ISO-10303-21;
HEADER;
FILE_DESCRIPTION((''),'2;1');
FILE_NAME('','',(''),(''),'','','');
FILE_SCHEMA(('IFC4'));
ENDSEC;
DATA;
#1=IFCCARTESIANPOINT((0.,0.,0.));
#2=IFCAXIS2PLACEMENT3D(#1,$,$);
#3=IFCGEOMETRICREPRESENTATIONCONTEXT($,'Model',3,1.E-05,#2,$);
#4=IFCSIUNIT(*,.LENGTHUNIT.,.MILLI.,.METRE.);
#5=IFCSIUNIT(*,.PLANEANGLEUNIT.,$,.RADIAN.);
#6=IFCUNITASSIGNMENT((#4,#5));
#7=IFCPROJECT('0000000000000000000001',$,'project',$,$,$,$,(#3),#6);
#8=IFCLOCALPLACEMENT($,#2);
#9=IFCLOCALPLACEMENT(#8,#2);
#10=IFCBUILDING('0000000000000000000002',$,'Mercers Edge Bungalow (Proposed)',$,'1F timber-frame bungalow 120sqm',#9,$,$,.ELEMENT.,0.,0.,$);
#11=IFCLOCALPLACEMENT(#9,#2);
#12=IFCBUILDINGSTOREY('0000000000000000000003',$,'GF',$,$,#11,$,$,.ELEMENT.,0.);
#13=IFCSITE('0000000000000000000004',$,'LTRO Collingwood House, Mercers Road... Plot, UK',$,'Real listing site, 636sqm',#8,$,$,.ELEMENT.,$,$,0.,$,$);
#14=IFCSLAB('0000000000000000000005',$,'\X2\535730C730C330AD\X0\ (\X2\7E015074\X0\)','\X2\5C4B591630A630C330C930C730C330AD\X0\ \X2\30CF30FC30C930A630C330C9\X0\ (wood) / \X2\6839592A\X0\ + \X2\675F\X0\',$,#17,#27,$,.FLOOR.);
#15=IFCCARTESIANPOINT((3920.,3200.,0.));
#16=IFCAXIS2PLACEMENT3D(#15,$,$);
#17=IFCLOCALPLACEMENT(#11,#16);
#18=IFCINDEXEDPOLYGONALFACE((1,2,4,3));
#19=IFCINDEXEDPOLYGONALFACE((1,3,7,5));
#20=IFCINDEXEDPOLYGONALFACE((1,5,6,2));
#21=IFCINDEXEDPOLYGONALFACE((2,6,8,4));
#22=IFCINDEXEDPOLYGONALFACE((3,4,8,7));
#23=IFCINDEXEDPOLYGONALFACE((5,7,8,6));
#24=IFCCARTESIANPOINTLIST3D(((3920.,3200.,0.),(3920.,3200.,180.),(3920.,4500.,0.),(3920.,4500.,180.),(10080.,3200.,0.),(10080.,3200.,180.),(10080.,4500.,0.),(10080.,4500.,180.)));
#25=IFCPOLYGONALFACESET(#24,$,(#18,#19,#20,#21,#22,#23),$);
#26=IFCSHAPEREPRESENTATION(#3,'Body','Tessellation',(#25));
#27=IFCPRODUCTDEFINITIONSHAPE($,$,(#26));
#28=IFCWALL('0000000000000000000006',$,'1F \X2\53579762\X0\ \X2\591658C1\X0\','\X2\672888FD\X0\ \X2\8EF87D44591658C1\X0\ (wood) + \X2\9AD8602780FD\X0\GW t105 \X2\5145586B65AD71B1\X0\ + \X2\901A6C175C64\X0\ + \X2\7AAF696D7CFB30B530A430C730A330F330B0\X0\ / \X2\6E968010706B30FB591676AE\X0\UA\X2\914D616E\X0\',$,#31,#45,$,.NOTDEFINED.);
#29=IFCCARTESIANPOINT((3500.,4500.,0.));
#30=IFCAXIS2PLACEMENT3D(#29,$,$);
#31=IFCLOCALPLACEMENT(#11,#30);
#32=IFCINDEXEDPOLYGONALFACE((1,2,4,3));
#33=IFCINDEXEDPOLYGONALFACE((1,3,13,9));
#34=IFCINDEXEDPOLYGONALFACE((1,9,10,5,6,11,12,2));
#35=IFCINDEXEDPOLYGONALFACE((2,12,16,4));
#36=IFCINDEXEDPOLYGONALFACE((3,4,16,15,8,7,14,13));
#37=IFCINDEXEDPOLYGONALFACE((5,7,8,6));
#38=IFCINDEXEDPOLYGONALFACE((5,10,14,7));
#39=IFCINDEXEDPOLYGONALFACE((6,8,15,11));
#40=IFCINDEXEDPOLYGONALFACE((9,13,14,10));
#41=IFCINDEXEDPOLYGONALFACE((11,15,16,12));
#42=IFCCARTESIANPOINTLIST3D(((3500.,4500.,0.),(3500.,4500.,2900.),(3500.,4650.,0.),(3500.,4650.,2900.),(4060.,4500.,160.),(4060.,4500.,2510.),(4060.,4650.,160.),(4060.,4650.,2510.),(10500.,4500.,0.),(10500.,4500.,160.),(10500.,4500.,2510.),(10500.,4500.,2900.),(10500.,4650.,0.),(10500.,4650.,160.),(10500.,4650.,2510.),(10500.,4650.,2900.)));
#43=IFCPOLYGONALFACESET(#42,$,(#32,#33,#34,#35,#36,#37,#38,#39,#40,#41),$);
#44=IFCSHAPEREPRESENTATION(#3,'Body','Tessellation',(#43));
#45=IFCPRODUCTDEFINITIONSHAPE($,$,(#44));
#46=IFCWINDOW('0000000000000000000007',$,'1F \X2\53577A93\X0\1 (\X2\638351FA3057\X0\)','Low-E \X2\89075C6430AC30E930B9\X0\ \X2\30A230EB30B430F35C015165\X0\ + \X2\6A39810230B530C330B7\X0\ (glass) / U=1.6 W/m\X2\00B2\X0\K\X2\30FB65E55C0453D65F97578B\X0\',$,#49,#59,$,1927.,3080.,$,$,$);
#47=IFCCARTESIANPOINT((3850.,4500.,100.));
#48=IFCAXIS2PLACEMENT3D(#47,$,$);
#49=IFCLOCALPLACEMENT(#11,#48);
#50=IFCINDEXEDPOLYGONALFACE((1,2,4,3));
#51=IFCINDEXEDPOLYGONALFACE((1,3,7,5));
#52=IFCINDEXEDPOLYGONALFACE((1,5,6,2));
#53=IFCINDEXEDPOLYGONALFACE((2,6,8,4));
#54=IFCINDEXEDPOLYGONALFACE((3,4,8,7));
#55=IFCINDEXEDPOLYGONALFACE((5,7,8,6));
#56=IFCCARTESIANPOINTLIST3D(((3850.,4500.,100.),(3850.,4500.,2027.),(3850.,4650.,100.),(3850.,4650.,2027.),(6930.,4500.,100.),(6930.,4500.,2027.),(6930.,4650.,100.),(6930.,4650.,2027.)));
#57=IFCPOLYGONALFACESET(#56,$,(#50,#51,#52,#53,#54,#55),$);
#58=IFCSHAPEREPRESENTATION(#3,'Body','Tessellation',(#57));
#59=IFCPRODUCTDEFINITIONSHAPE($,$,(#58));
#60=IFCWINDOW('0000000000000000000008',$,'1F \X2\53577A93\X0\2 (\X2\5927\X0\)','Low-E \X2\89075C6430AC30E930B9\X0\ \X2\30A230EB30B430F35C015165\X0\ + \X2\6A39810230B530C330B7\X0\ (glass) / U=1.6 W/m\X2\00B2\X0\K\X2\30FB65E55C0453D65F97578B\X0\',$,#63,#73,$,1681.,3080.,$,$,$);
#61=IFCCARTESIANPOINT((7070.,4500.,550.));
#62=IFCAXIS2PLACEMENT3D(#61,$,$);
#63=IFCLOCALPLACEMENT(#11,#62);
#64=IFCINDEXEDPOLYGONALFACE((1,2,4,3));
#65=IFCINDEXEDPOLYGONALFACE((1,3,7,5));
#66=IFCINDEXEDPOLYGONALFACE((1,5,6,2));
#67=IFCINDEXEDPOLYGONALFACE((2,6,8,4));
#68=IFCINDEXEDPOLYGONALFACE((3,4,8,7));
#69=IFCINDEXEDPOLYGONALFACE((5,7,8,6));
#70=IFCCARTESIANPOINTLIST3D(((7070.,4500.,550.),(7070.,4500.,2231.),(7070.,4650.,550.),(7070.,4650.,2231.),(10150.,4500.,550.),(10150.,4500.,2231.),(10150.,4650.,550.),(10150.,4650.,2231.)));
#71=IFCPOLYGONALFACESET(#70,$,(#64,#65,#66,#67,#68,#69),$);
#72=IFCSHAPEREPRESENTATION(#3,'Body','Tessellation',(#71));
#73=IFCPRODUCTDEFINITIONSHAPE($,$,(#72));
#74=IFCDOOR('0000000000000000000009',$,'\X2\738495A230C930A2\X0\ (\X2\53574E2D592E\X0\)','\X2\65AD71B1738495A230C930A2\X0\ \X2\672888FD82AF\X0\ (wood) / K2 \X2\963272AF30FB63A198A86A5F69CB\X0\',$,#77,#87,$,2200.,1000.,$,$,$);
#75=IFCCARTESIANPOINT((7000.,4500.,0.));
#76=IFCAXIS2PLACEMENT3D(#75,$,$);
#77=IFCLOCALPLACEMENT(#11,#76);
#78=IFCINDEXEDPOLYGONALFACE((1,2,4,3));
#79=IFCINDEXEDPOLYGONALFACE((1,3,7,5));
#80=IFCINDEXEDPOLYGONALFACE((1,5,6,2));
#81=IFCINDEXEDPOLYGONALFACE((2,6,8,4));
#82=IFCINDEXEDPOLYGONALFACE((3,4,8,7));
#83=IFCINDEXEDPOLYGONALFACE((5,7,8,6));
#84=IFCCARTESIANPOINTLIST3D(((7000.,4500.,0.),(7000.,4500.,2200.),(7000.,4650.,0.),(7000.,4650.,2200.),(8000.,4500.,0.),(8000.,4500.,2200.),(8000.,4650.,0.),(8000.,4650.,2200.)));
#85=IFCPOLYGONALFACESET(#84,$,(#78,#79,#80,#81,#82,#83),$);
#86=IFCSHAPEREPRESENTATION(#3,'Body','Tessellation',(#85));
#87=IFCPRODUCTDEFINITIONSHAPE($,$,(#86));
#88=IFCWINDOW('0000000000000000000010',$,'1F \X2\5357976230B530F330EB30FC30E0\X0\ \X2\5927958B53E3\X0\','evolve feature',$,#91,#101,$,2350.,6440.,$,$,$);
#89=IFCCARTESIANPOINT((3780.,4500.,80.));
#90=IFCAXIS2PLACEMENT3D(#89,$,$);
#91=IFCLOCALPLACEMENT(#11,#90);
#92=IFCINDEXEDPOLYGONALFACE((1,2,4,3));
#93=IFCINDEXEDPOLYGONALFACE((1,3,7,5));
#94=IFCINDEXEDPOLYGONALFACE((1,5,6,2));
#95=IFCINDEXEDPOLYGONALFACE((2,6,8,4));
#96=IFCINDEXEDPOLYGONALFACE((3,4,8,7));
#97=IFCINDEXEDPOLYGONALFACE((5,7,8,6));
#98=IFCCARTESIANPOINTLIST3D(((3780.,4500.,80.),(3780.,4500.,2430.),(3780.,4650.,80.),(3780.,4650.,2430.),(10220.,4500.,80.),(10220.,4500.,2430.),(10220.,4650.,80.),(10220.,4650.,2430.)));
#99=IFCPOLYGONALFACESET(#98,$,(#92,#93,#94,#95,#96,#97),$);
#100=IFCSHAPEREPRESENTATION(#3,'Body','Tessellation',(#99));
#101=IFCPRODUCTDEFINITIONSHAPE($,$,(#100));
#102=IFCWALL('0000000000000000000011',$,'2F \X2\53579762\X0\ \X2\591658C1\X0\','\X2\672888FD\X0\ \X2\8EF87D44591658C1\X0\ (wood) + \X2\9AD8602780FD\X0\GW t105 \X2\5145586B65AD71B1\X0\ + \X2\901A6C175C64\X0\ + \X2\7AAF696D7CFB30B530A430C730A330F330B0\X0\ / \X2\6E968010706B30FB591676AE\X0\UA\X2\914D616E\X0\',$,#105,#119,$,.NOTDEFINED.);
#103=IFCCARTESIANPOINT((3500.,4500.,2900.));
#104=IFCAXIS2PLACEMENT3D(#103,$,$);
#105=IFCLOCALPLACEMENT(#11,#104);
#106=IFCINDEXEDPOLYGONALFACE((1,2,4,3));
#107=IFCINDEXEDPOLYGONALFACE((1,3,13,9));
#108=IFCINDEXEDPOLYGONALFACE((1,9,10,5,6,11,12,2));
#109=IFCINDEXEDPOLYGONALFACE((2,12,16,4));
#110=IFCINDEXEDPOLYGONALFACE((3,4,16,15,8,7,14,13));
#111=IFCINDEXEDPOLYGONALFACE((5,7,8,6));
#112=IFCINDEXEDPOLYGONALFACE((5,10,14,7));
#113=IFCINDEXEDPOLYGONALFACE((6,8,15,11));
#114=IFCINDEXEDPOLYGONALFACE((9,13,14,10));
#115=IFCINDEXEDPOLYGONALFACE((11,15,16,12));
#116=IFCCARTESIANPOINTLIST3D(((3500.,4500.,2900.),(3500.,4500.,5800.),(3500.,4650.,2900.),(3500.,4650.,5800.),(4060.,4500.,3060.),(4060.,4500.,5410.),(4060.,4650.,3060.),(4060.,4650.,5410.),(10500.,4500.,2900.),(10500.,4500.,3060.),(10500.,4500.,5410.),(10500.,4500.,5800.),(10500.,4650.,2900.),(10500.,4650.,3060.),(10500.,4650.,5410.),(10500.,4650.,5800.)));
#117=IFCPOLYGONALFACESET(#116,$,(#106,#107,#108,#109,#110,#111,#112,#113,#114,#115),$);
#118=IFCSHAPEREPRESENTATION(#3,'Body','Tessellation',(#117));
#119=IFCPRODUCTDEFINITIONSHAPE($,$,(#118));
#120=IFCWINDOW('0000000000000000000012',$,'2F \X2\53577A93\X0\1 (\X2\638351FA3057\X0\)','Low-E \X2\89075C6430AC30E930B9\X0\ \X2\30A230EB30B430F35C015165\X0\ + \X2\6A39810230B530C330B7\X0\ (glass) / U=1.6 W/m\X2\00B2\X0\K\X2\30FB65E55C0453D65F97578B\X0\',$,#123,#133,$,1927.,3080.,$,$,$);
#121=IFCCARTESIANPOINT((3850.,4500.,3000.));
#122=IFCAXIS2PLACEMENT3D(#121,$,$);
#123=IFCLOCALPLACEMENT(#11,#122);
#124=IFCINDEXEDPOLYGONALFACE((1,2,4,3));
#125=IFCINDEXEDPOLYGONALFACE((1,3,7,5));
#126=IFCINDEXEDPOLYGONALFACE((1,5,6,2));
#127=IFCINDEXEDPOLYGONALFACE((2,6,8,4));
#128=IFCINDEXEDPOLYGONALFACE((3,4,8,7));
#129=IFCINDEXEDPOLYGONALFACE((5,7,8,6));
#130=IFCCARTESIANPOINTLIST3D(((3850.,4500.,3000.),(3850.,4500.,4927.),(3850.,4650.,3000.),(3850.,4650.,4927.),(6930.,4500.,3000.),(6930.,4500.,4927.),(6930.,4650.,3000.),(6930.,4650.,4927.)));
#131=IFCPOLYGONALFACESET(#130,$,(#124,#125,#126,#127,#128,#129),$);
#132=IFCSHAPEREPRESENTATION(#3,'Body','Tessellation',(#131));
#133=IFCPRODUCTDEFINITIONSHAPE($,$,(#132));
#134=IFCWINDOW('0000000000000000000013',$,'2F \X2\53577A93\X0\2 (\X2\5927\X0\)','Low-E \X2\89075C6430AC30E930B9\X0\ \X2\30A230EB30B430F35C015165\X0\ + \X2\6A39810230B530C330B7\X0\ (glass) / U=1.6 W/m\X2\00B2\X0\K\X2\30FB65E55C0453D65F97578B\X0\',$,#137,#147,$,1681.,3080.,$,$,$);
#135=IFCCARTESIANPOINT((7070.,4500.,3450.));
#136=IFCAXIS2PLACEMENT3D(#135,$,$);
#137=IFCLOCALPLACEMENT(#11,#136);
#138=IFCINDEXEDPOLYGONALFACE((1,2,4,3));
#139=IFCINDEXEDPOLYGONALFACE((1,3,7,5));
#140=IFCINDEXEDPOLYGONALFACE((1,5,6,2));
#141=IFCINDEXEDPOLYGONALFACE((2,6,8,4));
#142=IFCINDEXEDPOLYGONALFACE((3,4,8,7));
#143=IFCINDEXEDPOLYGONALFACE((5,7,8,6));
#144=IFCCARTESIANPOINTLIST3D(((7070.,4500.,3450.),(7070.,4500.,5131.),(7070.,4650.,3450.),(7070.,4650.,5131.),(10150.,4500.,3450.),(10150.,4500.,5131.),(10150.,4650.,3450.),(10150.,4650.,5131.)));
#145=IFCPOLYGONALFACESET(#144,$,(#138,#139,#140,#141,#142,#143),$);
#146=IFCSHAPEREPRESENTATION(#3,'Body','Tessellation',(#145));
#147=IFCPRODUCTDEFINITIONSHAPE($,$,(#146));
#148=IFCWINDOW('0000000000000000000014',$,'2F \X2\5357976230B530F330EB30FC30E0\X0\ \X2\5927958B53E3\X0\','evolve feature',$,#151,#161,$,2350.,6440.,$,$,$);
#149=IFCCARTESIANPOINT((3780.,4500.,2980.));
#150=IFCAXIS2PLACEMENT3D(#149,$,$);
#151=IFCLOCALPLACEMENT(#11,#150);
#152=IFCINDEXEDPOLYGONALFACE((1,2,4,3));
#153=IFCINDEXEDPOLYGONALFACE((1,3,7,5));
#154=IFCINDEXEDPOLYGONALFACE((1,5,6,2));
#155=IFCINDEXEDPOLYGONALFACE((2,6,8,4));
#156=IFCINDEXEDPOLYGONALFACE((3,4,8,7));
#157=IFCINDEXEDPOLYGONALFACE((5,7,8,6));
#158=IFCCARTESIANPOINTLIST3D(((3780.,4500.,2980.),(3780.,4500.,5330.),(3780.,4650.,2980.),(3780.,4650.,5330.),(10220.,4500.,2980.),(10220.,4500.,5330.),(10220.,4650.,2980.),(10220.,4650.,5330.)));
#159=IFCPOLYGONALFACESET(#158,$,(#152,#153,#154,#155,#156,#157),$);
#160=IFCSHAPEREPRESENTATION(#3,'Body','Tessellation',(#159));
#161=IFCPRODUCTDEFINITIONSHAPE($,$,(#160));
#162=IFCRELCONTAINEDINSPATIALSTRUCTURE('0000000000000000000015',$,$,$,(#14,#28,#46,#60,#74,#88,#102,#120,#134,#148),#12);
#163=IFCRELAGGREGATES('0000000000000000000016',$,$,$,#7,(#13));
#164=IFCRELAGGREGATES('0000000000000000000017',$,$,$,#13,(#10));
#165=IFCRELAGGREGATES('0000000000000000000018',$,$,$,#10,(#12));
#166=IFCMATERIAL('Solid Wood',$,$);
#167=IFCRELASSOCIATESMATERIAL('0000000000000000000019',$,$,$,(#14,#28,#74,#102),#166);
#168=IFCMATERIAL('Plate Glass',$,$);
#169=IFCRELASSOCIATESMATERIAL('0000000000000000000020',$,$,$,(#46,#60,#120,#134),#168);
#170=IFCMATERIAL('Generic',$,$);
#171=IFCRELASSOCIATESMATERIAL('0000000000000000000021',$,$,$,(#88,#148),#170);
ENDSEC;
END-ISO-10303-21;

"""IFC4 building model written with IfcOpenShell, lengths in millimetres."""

from ifc_helpers import new_model, si_unit, frame, frame_2d, origin, place, context, project, spatial, rectangle, extrude, material, element, fill, save


model = new_model("IFC4")

# Units and contexts
model_context = context("Model", 3, precision=1e-05, world=origin())
ifc_project = project(units=[si_unit("LENGTHUNIT", "METRE", prefix="MILLI"), si_unit("PLANEANGLEUNIT", "RADIAN")], contexts=[model_context])

# Site, building, storey
site_placement = place(None, origin())
site = spatial("IfcSite", under=ifc_project, at=site_placement, Name="LTRO Collingwood House, Mercers Road... Plot, UK", ObjectType="Real listing site, 636sqm", CompositionType="ELEMENT", RefElevation=0.0)
building_placement = place(site_placement, origin())
building = spatial("IfcBuilding", under=site, at=building_placement, Name="Mercers Edge Bungalow (Proposed)", ObjectType="1F timber-frame bungalow 120sqm", CompositionType="ELEMENT", ElevationOfRefHeight=0.0, ElevationOfTerrain=0.0)
storey_placement = place(building_placement, origin())
storey = spatial("IfcBuildingStorey", under=building, at=storey_placement, Name="GF", CompositionType="ELEMENT", Elevation=0.0)

# Slab
ifc_material_1 = material(Name="Solid Wood")
slab_1_placement = place(storey_placement, frame((3920.0, 3200.0, 0.0)))
element("IfcSlab", 1, at=slab_1_placement, inside=storey, material=ifc_material_1, Name="南デッキ (縁側)", Description="屋外ウッドデッキ ハードウッド (wood) / 根太 + 束", PredefinedType="FLOOR", context=model_context, shape_type="SweptSolid", body=[
    extrude(rectangle(XDim=6160.0, YDim=1300.0, at=frame_2d((3080.0, 650.0))), frame((3920.0, 3200.0, 0.0)), (0.0, 0.0, 1.0), 180.0),
])
ifc_material_2 = material(Name="Generic")

# Wall, openings, windows, door
wall_1_placement = place(storey_placement, frame((3500.0, 4500.0, 0.0)))
wall_1 = element("IfcWall", 2, at=wall_1_placement, inside=storey, material=ifc_material_1, Name="1F 南面 外壁", Description="木製 軸組外壁 (wood) + 高性能GW t105 充填断熱 + 通気層 + 窯業系サイディング / 準耐火・外皮UA配慮", PredefinedType="NOTDEFINED", context=model_context, shape_type="SweptSolid", body=[
    extrude(rectangle(XDim=7000.0, YDim=150.0, at=frame_2d((3500.0, 75.0))), frame((3500.0, 4500.0, 0.0)), (0.0, 0.0, 1.0), 2900.0),
])
opening_1_placement = place(storey_placement, frame((3850.0, 4500.0, 100.0)))
opening_1 = element("IfcOpeningElement", 3, at=opening_1_placement, cuts=wall_1, PredefinedType="NOTDEFINED", context=model_context, shape_type="SweptSolid", body=[
    extrude(rectangle(XDim=3080.0, YDim=150.0, at=frame_2d((1540.0, 75.0))), frame((3850.0, 4500.0, 100.0)), (0.0, 0.0, 1.0), 1927.0),
])
opening_2_placement = place(storey_placement, frame((7070.0, 4500.0, 550.0)))
opening_2 = element("IfcOpeningElement", 4, at=opening_2_placement, cuts=wall_1, PredefinedType="NOTDEFINED", context=model_context, shape_type="SweptSolid", body=[
    extrude(rectangle(XDim=3080.0, YDim=150.0, at=frame_2d((1540.0, 75.0))), frame((7070.0, 4500.0, 550.0)), (0.0, 0.0, 1.0), 1681.0),
])
opening_3_placement = place(storey_placement, frame((7000.0, 4500.0, 0.0)))
opening_3 = element("IfcOpeningElement", 5, at=opening_3_placement, cuts=wall_1, PredefinedType="NOTDEFINED", context=model_context, shape_type="SweptSolid", body=[
    extrude(rectangle(XDim=1000.0, YDim=150.0, at=frame_2d((500.0, 75.0))), frame((7000.0, 4500.0, 0.0)), (0.0, 0.0, 1.0), 2200.0),
])
opening_4_placement = place(storey_placement, frame((3780.0, 4500.0, 80.0)))
opening_4 = element("IfcOpeningElement", 6, at=opening_4_placement, cuts=wall_1, PredefinedType="NOTDEFINED", context=model_context, shape_type="SweptSolid", body=[
    extrude(rectangle(XDim=6440.0, YDim=150.0, at=frame_2d((3220.0, 75.0))), frame((3780.0, 4500.0, 80.0)), (0.0, 0.0, 1.0), 2350.0),
])
ifc_material_3 = material(Name="Plate Glass")
window_1_placement = place(storey_placement, frame((3850.0, 4500.0, 100.0)))
window_1 = element("IfcWindow", 7, at=window_1_placement, inside=storey, material=ifc_material_3, Name="1F 南窓1 (掃出し)", Description="Low-E 複層ガラス アルゴン封入 + 樹脂サッシ (glass) / U=1.6 W/m²K・日射取得型", OverallHeight=1927.0, OverallWidth=3080.0, context=model_context, shape_type="SweptSolid", body=[
    extrude(rectangle(XDim=3080.0, YDim=150.0, at=frame_2d((1540.0, 75.0))), frame((3850.0, 4500.0, 100.0)), (0.0, 0.0, 1.0), 1927.0),
])
fill(opening_1, window_1)
window_2_placement = place(storey_placement, frame((7070.0, 4500.0, 550.0)))
window_2 = element("IfcWindow", 8, at=window_2_placement, inside=storey, material=ifc_material_3, Name="1F 南窓2 (大)", Description="Low-E 複層ガラス アルゴン封入 + 樹脂サッシ (glass) / U=1.6 W/m²K・日射取得型", OverallHeight=1681.0, OverallWidth=3080.0, context=model_context, shape_type="SweptSolid", body=[
    extrude(rectangle(XDim=3080.0, YDim=150.0, at=frame_2d((1540.0, 75.0))), frame((7070.0, 4500.0, 550.0)), (0.0, 0.0, 1.0), 1681.0),
])
fill(opening_2, window_2)
door_placement = place(storey_placement, frame((7000.0, 4500.0, 0.0)))
door = element("IfcDoor", 9, at=door_placement, inside=storey, material=ifc_material_1, Name="玄関ドア (南中央)", Description="断熱玄関ドア 木製芯 (wood) / K2 防犯・採風機構", OverallHeight=2200.0, OverallWidth=1000.0, context=model_context, shape_type="SweptSolid", body=[
    extrude(rectangle(XDim=1000.0, YDim=150.0, at=frame_2d((500.0, 75.0))), frame((7000.0, 4500.0, 0.0)), (0.0, 0.0, 1.0), 2200.0),
])
fill(opening_3, door)
window_3_placement = place(storey_placement, frame((3780.0, 4500.0, 80.0)))
window_3 = element("IfcWindow", 10, at=window_3_placement, inside=storey, material=ifc_material_2, Name="1F 南面サンルーム 大開口", Description="evolve feature", OverallHeight=2350.0, OverallWidth=6440.0, context=model_context, shape_type="SweptSolid", body=[
    extrude(rectangle(XDim=6440.0, YDim=150.0, at=frame_2d((3220.0, 75.0))), frame((3780.0, 4500.0, 80.0)), (0.0, 0.0, 1.0), 2350.0),
])
fill(opening_4, window_3)

# Wall, openings, windows
wall_2_placement = place(storey_placement, frame((3500.0, 4500.0, 2900.0)))
wall_2 = element("IfcWall", 11, at=wall_2_placement, inside=storey, material=ifc_material_1, Name="2F 南面 外壁", Description="木製 軸組外壁 (wood) + 高性能GW t105 充填断熱 + 通気層 + 窯業系サイディング / 準耐火・外皮UA配慮", PredefinedType="NOTDEFINED", context=model_context, shape_type="SweptSolid", body=[
    extrude(rectangle(XDim=7000.0, YDim=150.0, at=frame_2d((3500.0, 75.0))), frame((3500.0, 4500.0, 2900.0)), (0.0, 0.0, 1.0), 2900.0),
])
opening_5_placement = place(storey_placement, frame((3850.0, 4500.0, 3000.0)))
opening_5 = element("IfcOpeningElement", 12, at=opening_5_placement, cuts=wall_2, PredefinedType="NOTDEFINED", context=model_context, shape_type="SweptSolid", body=[
    extrude(rectangle(XDim=3080.0, YDim=150.0, at=frame_2d((1540.0, 75.0))), frame((3850.0, 4500.0, 3000.0)), (0.0, 0.0, 1.0), 1927.0),
])
opening_6_placement = place(storey_placement, frame((7070.0, 4500.0, 3450.0)))
opening_6 = element("IfcOpeningElement", 13, at=opening_6_placement, cuts=wall_2, PredefinedType="NOTDEFINED", context=model_context, shape_type="SweptSolid", body=[
    extrude(rectangle(XDim=3080.0, YDim=150.0, at=frame_2d((1540.0, 75.0))), frame((7070.0, 4500.0, 3450.0)), (0.0, 0.0, 1.0), 1681.0),
])
opening_7_placement = place(storey_placement, frame((3780.0, 4500.0, 2980.0)))
opening_7 = element("IfcOpeningElement", 14, at=opening_7_placement, cuts=wall_2, PredefinedType="NOTDEFINED", context=model_context, shape_type="SweptSolid", body=[
    extrude(rectangle(XDim=6440.0, YDim=150.0, at=frame_2d((3220.0, 75.0))), frame((3780.0, 4500.0, 2980.0)), (0.0, 0.0, 1.0), 2350.0),
])
window_4_placement = place(storey_placement, frame((3850.0, 4500.0, 3000.0)))
window_4 = element("IfcWindow", 15, at=window_4_placement, inside=storey, material=ifc_material_3, Name="2F 南窓1 (掃出し)", Description="Low-E 複層ガラス アルゴン封入 + 樹脂サッシ (glass) / U=1.6 W/m²K・日射取得型", OverallHeight=1927.0, OverallWidth=3080.0, context=model_context, shape_type="SweptSolid", body=[
    extrude(rectangle(XDim=3080.0, YDim=150.0, at=frame_2d((1540.0, 75.0))), frame((3850.0, 4500.0, 3000.0)), (0.0, 0.0, 1.0), 1927.0),
])
fill(opening_5, window_4)
window_5_placement = place(storey_placement, frame((7070.0, 4500.0, 3450.0)))
window_5 = element("IfcWindow", 16, at=window_5_placement, inside=storey, material=ifc_material_3, Name="2F 南窓2 (大)", Description="Low-E 複層ガラス アルゴン封入 + 樹脂サッシ (glass) / U=1.6 W/m²K・日射取得型", OverallHeight=1681.0, OverallWidth=3080.0, context=model_context, shape_type="SweptSolid", body=[
    extrude(rectangle(XDim=3080.0, YDim=150.0, at=frame_2d((1540.0, 75.0))), frame((7070.0, 4500.0, 3450.0)), (0.0, 0.0, 1.0), 1681.0),
])
fill(opening_6, window_5)
window_6_placement = place(storey_placement, frame((3780.0, 4500.0, 2980.0)))
window_6 = element("IfcWindow", 17, at=window_6_placement, inside=storey, material=ifc_material_2, Name="2F 南面サンルーム 大開口", Description="evolve feature", OverallHeight=2350.0, OverallWidth=6440.0, context=model_context, shape_type="SweptSolid", body=[
    extrude(rectangle(XDim=6440.0, YDim=150.0, at=frame_2d((3220.0, 75.0))), frame((3780.0, 4500.0, 2980.0)), (0.0, 0.0, 1.0), 2350.0),
])
fill(opening_7, window_6)

save(model, "model.ifc")
